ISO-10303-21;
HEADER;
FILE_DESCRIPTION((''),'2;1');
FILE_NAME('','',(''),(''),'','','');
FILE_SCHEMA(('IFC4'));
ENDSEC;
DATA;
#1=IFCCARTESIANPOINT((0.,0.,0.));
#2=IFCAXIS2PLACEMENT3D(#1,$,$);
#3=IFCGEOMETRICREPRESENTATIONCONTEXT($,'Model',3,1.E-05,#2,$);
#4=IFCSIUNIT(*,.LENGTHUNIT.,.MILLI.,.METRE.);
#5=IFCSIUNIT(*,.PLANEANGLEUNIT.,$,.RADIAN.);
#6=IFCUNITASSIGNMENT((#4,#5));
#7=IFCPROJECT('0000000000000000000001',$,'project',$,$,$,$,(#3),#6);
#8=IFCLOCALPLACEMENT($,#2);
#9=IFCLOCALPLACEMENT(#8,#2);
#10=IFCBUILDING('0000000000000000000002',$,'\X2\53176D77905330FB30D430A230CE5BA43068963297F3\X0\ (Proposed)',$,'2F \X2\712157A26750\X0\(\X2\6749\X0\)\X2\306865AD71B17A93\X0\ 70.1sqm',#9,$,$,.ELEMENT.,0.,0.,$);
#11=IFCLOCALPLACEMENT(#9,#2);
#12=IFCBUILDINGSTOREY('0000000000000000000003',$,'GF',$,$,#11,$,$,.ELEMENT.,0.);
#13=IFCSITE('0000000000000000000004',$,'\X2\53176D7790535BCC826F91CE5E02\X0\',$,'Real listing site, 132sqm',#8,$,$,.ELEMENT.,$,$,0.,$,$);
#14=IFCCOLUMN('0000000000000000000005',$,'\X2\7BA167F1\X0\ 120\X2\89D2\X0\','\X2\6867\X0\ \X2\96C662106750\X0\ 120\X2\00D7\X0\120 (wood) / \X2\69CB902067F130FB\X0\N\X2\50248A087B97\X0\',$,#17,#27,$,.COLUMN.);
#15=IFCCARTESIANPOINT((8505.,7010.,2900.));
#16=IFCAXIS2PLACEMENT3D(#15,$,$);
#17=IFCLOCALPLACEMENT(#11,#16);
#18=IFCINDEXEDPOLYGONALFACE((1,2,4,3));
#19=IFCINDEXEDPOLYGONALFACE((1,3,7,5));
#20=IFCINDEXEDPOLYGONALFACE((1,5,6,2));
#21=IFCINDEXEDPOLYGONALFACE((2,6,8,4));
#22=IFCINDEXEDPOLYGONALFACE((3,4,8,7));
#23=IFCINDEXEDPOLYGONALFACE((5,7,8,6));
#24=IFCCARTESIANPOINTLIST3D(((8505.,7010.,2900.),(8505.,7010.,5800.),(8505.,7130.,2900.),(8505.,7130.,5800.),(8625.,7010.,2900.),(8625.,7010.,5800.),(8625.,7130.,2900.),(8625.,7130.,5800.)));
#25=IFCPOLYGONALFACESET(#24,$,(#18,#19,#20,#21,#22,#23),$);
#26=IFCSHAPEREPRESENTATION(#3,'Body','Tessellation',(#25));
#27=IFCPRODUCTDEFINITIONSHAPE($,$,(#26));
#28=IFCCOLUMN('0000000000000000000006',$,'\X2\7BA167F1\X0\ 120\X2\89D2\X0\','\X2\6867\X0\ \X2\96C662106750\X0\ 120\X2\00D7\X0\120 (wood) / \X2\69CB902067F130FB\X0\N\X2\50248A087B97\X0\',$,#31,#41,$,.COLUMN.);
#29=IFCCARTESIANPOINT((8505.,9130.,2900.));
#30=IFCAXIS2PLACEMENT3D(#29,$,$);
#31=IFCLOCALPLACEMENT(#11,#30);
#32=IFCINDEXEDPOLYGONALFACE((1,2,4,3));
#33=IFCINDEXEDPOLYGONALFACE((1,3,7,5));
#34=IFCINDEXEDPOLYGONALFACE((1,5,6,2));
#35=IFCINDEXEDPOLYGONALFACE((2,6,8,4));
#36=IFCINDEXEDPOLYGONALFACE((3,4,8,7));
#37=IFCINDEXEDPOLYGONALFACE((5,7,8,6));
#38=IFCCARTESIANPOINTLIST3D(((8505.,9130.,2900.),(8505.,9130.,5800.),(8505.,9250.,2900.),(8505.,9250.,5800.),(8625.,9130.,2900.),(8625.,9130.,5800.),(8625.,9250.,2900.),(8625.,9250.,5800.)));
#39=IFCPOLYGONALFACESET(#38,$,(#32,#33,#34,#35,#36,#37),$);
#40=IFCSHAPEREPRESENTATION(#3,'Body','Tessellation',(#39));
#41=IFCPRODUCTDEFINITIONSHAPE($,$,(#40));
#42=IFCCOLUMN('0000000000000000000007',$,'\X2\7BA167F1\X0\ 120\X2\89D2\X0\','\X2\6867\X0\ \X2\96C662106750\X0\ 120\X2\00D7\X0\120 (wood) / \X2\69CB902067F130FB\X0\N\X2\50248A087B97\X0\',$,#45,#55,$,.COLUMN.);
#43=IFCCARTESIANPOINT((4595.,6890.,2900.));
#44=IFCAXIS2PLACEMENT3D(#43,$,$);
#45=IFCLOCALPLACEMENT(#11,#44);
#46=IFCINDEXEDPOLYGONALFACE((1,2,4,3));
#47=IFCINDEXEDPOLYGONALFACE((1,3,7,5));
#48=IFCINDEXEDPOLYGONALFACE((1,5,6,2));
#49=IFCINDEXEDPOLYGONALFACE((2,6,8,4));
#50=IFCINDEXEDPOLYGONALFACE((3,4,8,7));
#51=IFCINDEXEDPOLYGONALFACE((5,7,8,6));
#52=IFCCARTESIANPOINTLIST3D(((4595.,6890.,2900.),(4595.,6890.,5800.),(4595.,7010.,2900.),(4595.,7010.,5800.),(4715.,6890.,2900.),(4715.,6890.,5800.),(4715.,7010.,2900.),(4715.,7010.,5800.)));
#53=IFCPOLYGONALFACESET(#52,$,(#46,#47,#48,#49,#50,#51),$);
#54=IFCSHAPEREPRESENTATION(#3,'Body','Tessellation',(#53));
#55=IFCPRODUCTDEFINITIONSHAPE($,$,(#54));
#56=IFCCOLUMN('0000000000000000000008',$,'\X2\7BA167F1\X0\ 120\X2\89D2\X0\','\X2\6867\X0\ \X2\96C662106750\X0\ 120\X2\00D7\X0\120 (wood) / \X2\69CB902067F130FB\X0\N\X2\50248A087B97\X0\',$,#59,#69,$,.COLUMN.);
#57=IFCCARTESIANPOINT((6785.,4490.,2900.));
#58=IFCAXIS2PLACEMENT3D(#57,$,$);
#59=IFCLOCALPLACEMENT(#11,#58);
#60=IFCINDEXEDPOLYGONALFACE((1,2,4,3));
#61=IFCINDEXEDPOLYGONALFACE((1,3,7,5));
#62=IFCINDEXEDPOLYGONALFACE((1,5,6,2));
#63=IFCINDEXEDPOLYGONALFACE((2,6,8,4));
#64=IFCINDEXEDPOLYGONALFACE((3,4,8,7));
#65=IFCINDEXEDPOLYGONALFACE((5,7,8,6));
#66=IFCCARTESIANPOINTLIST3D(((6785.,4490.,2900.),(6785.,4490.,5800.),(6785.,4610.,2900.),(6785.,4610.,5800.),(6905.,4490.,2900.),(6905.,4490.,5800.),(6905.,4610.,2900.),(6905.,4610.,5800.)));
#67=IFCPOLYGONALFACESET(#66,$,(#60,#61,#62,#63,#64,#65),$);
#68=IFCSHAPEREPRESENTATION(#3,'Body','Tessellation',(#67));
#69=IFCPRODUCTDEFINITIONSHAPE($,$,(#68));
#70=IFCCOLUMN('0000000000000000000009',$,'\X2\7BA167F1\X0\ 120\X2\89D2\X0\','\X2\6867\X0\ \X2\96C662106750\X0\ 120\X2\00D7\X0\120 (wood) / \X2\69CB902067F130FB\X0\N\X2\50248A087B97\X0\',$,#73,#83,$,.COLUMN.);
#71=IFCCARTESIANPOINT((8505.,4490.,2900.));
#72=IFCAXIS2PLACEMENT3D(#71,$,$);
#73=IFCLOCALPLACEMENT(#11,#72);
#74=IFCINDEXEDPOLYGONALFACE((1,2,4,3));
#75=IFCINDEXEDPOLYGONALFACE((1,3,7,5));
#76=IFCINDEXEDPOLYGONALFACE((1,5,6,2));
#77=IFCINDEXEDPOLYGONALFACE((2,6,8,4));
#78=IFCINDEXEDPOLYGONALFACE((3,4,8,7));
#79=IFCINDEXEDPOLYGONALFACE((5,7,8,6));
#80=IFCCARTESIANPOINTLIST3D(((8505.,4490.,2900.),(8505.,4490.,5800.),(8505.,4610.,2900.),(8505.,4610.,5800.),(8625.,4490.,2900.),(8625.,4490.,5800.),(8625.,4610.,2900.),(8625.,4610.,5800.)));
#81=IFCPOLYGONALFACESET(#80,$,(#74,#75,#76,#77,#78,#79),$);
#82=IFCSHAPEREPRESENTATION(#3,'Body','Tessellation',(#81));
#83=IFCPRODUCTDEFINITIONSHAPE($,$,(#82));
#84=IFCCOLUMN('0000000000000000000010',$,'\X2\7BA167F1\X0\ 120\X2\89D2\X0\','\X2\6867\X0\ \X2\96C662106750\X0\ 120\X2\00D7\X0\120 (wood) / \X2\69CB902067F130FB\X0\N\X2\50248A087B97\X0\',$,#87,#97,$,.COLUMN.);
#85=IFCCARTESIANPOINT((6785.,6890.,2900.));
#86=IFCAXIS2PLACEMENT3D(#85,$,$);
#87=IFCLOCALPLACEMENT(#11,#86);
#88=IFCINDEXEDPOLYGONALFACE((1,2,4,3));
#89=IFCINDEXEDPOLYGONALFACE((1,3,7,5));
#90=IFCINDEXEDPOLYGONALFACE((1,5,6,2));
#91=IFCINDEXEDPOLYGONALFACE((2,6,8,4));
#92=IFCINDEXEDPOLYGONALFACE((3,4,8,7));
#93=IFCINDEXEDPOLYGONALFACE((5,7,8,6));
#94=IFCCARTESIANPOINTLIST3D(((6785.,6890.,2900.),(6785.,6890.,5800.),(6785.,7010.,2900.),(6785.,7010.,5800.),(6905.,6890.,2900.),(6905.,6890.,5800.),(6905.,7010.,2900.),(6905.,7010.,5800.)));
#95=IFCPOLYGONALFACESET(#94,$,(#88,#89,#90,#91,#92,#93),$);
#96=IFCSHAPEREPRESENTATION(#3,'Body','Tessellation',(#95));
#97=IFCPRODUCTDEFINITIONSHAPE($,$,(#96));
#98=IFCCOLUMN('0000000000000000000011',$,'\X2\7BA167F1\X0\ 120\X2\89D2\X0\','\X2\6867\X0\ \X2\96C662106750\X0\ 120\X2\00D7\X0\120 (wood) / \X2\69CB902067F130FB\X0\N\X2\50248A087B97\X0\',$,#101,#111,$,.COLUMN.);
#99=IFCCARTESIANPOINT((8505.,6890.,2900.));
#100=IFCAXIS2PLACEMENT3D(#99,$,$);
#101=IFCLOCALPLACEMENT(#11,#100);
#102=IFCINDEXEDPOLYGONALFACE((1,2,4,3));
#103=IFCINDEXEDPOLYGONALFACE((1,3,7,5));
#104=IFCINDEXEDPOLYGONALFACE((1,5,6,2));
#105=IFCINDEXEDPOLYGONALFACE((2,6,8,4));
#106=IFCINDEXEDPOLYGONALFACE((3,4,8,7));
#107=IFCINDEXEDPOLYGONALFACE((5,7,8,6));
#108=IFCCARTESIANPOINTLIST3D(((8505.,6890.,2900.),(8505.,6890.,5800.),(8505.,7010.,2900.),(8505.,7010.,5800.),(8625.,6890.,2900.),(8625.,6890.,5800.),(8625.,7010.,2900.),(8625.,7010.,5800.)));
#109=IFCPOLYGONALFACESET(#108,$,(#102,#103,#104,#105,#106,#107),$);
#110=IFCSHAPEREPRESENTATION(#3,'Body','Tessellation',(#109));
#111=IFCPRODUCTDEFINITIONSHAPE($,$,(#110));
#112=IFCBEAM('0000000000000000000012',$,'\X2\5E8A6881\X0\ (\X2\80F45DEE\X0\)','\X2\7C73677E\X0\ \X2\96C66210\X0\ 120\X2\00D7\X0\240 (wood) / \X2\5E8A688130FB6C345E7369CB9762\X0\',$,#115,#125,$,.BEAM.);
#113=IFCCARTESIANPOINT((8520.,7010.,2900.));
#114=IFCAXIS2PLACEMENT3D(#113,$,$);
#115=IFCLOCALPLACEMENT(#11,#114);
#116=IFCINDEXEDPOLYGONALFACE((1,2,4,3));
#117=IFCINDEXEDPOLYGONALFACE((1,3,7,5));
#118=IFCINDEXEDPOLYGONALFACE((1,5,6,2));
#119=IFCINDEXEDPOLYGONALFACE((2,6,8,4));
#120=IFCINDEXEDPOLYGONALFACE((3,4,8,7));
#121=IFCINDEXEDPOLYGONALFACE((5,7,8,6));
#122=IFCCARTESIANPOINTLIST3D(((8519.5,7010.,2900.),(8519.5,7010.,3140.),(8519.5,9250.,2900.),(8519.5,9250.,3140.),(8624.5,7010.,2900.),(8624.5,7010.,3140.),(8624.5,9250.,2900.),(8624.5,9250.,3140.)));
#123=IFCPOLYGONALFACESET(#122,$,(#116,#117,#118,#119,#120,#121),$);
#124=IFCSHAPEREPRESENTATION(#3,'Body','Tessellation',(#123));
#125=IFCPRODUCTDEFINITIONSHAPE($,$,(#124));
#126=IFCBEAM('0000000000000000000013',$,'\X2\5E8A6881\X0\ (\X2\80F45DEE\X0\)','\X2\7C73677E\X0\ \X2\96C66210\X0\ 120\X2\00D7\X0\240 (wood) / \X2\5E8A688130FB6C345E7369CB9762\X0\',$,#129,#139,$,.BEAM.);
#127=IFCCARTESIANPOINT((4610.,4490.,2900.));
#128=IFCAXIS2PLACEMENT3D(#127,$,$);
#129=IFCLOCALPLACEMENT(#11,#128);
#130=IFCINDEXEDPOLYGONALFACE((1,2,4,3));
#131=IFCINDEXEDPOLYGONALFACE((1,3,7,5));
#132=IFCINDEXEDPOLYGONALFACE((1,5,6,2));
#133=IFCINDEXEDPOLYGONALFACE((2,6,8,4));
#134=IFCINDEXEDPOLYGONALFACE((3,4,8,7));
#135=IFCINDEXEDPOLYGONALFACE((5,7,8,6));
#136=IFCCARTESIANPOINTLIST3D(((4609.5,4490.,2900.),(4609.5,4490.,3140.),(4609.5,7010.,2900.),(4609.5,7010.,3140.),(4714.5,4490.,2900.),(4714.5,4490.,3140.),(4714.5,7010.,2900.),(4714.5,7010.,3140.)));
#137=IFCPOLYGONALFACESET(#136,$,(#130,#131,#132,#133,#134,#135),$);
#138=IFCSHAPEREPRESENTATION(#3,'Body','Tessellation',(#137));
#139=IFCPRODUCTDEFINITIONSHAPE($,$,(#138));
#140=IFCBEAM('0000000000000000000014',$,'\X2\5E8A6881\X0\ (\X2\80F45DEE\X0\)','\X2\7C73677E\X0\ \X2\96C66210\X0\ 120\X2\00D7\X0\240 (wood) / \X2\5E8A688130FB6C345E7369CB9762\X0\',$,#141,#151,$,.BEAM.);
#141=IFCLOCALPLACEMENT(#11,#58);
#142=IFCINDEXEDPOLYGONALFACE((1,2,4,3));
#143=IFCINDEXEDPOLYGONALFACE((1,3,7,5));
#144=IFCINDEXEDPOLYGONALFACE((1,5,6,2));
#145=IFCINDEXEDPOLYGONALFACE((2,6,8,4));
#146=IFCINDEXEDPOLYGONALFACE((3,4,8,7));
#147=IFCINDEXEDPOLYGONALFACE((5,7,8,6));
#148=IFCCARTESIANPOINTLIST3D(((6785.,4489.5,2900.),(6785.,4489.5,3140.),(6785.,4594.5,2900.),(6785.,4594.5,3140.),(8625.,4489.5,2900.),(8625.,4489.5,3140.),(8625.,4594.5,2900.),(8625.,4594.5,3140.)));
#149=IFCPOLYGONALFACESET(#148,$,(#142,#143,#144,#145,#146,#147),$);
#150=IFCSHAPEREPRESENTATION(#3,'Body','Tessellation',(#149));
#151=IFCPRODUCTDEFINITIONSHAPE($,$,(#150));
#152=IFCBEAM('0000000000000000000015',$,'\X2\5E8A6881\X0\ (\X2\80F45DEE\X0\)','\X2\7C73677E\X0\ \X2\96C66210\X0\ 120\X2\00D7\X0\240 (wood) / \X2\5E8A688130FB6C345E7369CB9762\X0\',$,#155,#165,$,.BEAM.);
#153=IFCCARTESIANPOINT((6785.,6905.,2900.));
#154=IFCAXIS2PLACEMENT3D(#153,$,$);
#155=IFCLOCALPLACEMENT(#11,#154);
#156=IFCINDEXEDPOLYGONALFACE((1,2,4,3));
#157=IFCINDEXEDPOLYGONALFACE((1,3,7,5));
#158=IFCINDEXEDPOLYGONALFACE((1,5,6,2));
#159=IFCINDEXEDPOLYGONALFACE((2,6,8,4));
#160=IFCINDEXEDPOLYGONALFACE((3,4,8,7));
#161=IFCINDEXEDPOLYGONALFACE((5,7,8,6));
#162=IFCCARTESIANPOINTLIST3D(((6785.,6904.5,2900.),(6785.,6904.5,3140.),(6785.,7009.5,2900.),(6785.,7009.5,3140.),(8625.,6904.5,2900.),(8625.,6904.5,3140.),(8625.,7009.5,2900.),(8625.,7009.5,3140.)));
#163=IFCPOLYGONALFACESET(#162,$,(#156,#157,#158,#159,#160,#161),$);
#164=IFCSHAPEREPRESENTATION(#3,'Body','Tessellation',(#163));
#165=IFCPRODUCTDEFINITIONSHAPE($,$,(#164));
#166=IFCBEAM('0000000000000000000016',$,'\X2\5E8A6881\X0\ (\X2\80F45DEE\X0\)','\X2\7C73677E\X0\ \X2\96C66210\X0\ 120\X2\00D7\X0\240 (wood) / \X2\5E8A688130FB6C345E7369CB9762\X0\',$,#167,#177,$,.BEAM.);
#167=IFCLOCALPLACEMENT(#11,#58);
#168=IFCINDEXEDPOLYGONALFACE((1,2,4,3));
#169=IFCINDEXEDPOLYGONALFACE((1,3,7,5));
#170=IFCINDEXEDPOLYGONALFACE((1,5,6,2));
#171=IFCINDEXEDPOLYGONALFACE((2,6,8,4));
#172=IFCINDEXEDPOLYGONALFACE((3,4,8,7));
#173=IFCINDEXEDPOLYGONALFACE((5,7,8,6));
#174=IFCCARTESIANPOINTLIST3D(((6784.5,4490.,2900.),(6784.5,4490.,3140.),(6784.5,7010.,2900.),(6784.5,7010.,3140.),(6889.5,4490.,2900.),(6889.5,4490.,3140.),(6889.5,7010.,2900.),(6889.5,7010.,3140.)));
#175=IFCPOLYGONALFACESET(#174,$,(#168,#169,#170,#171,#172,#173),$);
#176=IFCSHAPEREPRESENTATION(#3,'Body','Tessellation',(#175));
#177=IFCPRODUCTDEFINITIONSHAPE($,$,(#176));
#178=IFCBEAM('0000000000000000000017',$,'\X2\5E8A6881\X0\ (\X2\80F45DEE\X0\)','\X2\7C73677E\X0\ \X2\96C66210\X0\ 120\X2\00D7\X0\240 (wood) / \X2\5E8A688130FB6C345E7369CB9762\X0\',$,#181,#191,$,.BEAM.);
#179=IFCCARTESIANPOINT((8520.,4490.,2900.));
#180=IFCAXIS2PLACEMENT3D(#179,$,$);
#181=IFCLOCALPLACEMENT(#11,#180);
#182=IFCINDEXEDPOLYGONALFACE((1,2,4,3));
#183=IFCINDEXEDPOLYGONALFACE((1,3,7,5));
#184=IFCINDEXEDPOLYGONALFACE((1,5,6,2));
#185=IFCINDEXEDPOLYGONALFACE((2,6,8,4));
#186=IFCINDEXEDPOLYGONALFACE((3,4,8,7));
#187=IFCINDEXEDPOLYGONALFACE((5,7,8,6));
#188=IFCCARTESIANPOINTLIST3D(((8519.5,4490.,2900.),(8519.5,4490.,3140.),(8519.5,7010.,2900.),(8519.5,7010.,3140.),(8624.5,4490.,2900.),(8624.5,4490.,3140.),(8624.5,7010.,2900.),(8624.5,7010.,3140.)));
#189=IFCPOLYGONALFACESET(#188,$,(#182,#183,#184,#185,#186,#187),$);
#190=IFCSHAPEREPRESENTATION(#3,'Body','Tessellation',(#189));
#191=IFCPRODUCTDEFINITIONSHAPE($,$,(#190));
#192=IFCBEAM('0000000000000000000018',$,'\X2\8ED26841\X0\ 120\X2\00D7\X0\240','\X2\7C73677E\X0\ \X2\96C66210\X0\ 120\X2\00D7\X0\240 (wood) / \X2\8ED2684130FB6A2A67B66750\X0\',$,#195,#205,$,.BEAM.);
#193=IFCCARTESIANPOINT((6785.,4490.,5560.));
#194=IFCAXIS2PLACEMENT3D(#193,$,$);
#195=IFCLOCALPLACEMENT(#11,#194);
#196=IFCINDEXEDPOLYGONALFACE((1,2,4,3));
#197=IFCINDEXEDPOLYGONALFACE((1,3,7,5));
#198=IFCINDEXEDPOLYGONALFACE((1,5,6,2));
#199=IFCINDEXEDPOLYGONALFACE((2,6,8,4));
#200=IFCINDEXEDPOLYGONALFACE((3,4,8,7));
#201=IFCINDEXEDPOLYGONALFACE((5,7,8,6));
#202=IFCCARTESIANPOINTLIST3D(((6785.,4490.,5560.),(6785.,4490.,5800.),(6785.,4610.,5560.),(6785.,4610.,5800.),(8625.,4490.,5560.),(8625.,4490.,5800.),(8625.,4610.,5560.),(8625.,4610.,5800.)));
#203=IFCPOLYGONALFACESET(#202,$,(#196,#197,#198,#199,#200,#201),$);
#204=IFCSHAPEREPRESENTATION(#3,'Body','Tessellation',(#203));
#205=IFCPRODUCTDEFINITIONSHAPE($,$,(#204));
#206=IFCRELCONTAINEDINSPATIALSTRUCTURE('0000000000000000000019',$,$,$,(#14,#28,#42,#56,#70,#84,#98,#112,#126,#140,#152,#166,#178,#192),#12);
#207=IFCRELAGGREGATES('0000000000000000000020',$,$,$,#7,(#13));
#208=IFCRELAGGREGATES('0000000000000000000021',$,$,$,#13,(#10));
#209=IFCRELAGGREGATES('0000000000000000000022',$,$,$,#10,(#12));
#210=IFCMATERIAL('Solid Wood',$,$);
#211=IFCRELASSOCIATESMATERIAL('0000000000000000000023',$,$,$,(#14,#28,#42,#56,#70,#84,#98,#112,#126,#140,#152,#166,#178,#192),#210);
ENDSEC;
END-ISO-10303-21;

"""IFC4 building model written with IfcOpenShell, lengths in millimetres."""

from ifc_helpers import new_model, si_unit, frame, frame_2d, origin, place, context, project, spatial, rectangle, extrude, material, element, save


model = new_model("IFC4")

# Units and contexts
model_context = context("Model", 3, precision=1e-05, world=origin())
ifc_project = project(units=[si_unit("LENGTHUNIT", "METRE", prefix="MILLI"), si_unit("PLANEANGLEUNIT", "RADIAN")], contexts=[model_context])

# Site, building, storey
site_placement = place(None, origin())
site = spatial("IfcSite", under=ifc_project, at=site_placement, Name="北海道富良野市", ObjectType="Real listing site, 132sqm", CompositionType="ELEMENT", RefElevation=0.0)
building_placement = place(site_placement, origin())
building = spatial("IfcBuilding", under=site, at=building_placement, Name="北海道・ピアノ室と防音 (Proposed)", ObjectType="2F 無垢材(杉)と断熱窓 70.1sqm", CompositionType="ELEMENT", ElevationOfRefHeight=0.0, ElevationOfTerrain=0.0)
storey_placement = place(building_placement, origin())
storey = spatial("IfcBuildingStorey", under=building, at=storey_placement, Name="GF", CompositionType="ELEMENT", Elevation=0.0)

# Columns
ifc_material_1 = material(Name="Solid Wood")
column_1_placement = place(storey_placement, frame((8505.0, 7010.0, 2900.0)))
element("IfcColumn", 1, at=column_1_placement, inside=storey, material=ifc_material_1, Name="管柱 120角", Description="桧 集成材 120×120 (wood) / 構造柱・N値計算", PredefinedType="COLUMN", context=model_context, shape_type="SweptSolid", body=[
    extrude(rectangle(XDim=120.0, YDim=120.0, at=frame_2d((60.0, 60.0))), frame((8505.0, 7010.0, 2900.0)), (0.0, 0.0, 1.0), 2900.0),
])
column_2_placement = place(storey_placement, frame((8505.0, 9130.0, 2900.0)))
element("IfcColumn", 2, at=column_2_placement, inside=storey, material=ifc_material_1, Name="管柱 120角", Description="桧 集成材 120×120 (wood) / 構造柱・N値計算", PredefinedType="COLUMN", context=model_context, shape_type="SweptSolid", body=[
    extrude(rectangle(XDim=120.0, YDim=120.0, at=frame_2d((60.0, 60.0))), frame((8505.0, 9130.0, 2900.0)), (0.0, 0.0, 1.0), 2900.0),
])
column_3_placement = place(storey_placement, frame((4595.0, 6890.0, 2900.0)))
element("IfcColumn", 3, at=column_3_placement, inside=storey, material=ifc_material_1, Name="管柱 120角", Description="桧 集成材 120×120 (wood) / 構造柱・N値計算", PredefinedType="COLUMN", context=model_context, shape_type="SweptSolid", body=[
    extrude(rectangle(XDim=120.0, YDim=120.0, at=frame_2d((60.0, 60.0))), frame((4595.0, 6890.0, 2900.0)), (0.0, 0.0, 1.0), 2900.0),
])
column_4_placement = place(storey_placement, frame((6785.0, 4490.0, 2900.0)))
element("IfcColumn", 4, at=column_4_placement, inside=storey, material=ifc_material_1, Name="管柱 120角", Description="桧 集成材 120×120 (wood) / 構造柱・N値計算", PredefinedType="COLUMN", context=model_context, shape_type="SweptSolid", body=[
    extrude(rectangle(XDim=120.0, YDim=120.0, at=frame_2d((60.0, 60.0))), frame((6785.0, 4490.0, 2900.0)), (0.0, 0.0, 1.0), 2900.0),
])
column_5_placement = place(storey_placement, frame((8505.0, 4490.0, 2900.0)))
element("IfcColumn", 5, at=column_5_placement, inside=storey, material=ifc_material_1, Name="管柱 120角", Description="桧 集成材 120×120 (wood) / 構造柱・N値計算", PredefinedType="COLUMN", context=model_context, shape_type="SweptSolid", body=[
    extrude(rectangle(XDim=120.0, YDim=120.0, at=frame_2d((60.0, 60.0))), frame((8505.0, 4490.0, 2900.0)), (0.0, 0.0, 1.0), 2900.0),
])
column_6_placement = place(storey_placement, frame((6785.0, 6890.0, 2900.0)))
element("IfcColumn", 6, at=column_6_placement, inside=storey, material=ifc_material_1, Name="管柱 120角", Description="桧 集成材 120×120 (wood) / 構造柱・N値計算", PredefinedType="COLUMN", context=model_context, shape_type="SweptSolid", body=[
    extrude(rectangle(XDim=120.0, YDim=120.0, at=frame_2d((60.0, 60.0))), frame((6785.0, 6890.0, 2900.0)), (0.0, 0.0, 1.0), 2900.0),
])
column_7_placement = place(storey_placement, frame((8505.0, 6890.0, 2900.0)))
element("IfcColumn", 7, at=column_7_placement, inside=storey, material=ifc_material_1, Name="管柱 120角", Description="桧 集成材 120×120 (wood) / 構造柱・N値計算", PredefinedType="COLUMN", context=model_context, shape_type="SweptSolid", body=[
    extrude(rectangle(XDim=120.0, YDim=120.0, at=frame_2d((60.0, 60.0))), frame((8505.0, 6890.0, 2900.0)), (0.0, 0.0, 1.0), 2900.0),
])

# Beams
beam_1_placement = place(storey_placement, frame((8520.0, 7010.0, 2900.0)))
element("IfcBeam", 8, at=beam_1_placement, inside=storey, material=ifc_material_1, Name="床梁 (胴差)", Description="米松 集成 120×240 (wood) / 床梁・水平構面", PredefinedType="BEAM", context=model_context, shape_type="SweptSolid", body=[
    extrude(rectangle(XDim=105.0, YDim=2240.0, at=frame_2d((52.0, 1120.0))), frame((8520.0, 7010.0, 2900.0)), (0.0, 0.0, 1.0), 240.0),
])
beam_2_placement = place(storey_placement, frame((4610.0, 4490.0, 2900.0)))
element("IfcBeam", 9, at=beam_2_placement, inside=storey, material=ifc_material_1, Name="床梁 (胴差)", Description="米松 集成 120×240 (wood) / 床梁・水平構面", PredefinedType="BEAM", context=model_context, shape_type="SweptSolid", body=[
    extrude(rectangle(XDim=105.0, YDim=2520.0, at=frame_2d((52.0, 1260.0))), frame((4610.0, 4490.0, 2900.0)), (0.0, 0.0, 1.0), 240.0),
])
beam_3_placement = place(storey_placement, frame((6785.0, 4490.0, 2900.0)))
element("IfcBeam", 10, at=beam_3_placement, inside=storey, material=ifc_material_1, Name="床梁 (胴差)", Description="米松 集成 120×240 (wood) / 床梁・水平構面", PredefinedType="BEAM", context=model_context, shape_type="SweptSolid", body=[
    extrude(rectangle(XDim=1840.0, YDim=105.0, at=frame_2d((920.0, 52.0))), frame((6785.0, 4490.0, 2900.0)), (0.0, 0.0, 1.0), 240.0),
])
beam_4_placement = place(storey_placement, frame((6785.0, 6905.0, 2900.0)))
element("IfcBeam", 11, at=beam_4_placement, inside=storey, material=ifc_material_1, Name="床梁 (胴差)", Description="米松 集成 120×240 (wood) / 床梁・水平構面", PredefinedType="BEAM", context=model_context, shape_type="SweptSolid", body=[
    extrude(rectangle(XDim=1840.0, YDim=105.0, at=frame_2d((920.0, 52.0))), frame((6785.0, 6905.0, 2900.0)), (0.0, 0.0, 1.0), 240.0),
])
beam_5_placement = place(storey_placement, frame((6785.0, 4490.0, 2900.0)))
element("IfcBeam", 12, at=beam_5_placement, inside=storey, material=ifc_material_1, Name="床梁 (胴差)", Description="米松 集成 120×240 (wood) / 床梁・水平構面", PredefinedType="BEAM", context=model_context, shape_type="SweptSolid", body=[
    extrude(rectangle(XDim=105.0, YDim=2520.0, at=frame_2d((52.0, 1260.0))), frame((6785.0, 4490.0, 2900.0)), (0.0, 0.0, 1.0), 240.0),
])
beam_6_placement = place(storey_placement, frame((8520.0, 4490.0, 2900.0)))
element("IfcBeam", 13, at=beam_6_placement, inside=storey, material=ifc_material_1, Name="床梁 (胴差)", Description="米松 集成 120×240 (wood) / 床梁・水平構面", PredefinedType="BEAM", context=model_context, shape_type="SweptSolid", body=[
    extrude(rectangle(XDim=105.0, YDim=2520.0, at=frame_2d((52.0, 1260.0))), frame((8520.0, 4490.0, 2900.0)), (0.0, 0.0, 1.0), 240.0),
])
beam_7_placement = place(storey_placement, frame((6785.0, 4490.0, 5560.0)))
element("IfcBeam", 14, at=beam_7_placement, inside=storey, material=ifc_material_1, Name="軒桁 120×240", Description="米松 集成 120×240 (wood) / 軒桁・横架材", PredefinedType="BEAM", context=model_context, shape_type="SweptSolid", body=[
    extrude(rectangle(XDim=1840.0, YDim=120.0, at=frame_2d((920.0, 60.0))), frame((6785.0, 4490.0, 5560.0)), (0.0, 0.0, 1.0), 240.0),
])

save(model, "model.ifc")
